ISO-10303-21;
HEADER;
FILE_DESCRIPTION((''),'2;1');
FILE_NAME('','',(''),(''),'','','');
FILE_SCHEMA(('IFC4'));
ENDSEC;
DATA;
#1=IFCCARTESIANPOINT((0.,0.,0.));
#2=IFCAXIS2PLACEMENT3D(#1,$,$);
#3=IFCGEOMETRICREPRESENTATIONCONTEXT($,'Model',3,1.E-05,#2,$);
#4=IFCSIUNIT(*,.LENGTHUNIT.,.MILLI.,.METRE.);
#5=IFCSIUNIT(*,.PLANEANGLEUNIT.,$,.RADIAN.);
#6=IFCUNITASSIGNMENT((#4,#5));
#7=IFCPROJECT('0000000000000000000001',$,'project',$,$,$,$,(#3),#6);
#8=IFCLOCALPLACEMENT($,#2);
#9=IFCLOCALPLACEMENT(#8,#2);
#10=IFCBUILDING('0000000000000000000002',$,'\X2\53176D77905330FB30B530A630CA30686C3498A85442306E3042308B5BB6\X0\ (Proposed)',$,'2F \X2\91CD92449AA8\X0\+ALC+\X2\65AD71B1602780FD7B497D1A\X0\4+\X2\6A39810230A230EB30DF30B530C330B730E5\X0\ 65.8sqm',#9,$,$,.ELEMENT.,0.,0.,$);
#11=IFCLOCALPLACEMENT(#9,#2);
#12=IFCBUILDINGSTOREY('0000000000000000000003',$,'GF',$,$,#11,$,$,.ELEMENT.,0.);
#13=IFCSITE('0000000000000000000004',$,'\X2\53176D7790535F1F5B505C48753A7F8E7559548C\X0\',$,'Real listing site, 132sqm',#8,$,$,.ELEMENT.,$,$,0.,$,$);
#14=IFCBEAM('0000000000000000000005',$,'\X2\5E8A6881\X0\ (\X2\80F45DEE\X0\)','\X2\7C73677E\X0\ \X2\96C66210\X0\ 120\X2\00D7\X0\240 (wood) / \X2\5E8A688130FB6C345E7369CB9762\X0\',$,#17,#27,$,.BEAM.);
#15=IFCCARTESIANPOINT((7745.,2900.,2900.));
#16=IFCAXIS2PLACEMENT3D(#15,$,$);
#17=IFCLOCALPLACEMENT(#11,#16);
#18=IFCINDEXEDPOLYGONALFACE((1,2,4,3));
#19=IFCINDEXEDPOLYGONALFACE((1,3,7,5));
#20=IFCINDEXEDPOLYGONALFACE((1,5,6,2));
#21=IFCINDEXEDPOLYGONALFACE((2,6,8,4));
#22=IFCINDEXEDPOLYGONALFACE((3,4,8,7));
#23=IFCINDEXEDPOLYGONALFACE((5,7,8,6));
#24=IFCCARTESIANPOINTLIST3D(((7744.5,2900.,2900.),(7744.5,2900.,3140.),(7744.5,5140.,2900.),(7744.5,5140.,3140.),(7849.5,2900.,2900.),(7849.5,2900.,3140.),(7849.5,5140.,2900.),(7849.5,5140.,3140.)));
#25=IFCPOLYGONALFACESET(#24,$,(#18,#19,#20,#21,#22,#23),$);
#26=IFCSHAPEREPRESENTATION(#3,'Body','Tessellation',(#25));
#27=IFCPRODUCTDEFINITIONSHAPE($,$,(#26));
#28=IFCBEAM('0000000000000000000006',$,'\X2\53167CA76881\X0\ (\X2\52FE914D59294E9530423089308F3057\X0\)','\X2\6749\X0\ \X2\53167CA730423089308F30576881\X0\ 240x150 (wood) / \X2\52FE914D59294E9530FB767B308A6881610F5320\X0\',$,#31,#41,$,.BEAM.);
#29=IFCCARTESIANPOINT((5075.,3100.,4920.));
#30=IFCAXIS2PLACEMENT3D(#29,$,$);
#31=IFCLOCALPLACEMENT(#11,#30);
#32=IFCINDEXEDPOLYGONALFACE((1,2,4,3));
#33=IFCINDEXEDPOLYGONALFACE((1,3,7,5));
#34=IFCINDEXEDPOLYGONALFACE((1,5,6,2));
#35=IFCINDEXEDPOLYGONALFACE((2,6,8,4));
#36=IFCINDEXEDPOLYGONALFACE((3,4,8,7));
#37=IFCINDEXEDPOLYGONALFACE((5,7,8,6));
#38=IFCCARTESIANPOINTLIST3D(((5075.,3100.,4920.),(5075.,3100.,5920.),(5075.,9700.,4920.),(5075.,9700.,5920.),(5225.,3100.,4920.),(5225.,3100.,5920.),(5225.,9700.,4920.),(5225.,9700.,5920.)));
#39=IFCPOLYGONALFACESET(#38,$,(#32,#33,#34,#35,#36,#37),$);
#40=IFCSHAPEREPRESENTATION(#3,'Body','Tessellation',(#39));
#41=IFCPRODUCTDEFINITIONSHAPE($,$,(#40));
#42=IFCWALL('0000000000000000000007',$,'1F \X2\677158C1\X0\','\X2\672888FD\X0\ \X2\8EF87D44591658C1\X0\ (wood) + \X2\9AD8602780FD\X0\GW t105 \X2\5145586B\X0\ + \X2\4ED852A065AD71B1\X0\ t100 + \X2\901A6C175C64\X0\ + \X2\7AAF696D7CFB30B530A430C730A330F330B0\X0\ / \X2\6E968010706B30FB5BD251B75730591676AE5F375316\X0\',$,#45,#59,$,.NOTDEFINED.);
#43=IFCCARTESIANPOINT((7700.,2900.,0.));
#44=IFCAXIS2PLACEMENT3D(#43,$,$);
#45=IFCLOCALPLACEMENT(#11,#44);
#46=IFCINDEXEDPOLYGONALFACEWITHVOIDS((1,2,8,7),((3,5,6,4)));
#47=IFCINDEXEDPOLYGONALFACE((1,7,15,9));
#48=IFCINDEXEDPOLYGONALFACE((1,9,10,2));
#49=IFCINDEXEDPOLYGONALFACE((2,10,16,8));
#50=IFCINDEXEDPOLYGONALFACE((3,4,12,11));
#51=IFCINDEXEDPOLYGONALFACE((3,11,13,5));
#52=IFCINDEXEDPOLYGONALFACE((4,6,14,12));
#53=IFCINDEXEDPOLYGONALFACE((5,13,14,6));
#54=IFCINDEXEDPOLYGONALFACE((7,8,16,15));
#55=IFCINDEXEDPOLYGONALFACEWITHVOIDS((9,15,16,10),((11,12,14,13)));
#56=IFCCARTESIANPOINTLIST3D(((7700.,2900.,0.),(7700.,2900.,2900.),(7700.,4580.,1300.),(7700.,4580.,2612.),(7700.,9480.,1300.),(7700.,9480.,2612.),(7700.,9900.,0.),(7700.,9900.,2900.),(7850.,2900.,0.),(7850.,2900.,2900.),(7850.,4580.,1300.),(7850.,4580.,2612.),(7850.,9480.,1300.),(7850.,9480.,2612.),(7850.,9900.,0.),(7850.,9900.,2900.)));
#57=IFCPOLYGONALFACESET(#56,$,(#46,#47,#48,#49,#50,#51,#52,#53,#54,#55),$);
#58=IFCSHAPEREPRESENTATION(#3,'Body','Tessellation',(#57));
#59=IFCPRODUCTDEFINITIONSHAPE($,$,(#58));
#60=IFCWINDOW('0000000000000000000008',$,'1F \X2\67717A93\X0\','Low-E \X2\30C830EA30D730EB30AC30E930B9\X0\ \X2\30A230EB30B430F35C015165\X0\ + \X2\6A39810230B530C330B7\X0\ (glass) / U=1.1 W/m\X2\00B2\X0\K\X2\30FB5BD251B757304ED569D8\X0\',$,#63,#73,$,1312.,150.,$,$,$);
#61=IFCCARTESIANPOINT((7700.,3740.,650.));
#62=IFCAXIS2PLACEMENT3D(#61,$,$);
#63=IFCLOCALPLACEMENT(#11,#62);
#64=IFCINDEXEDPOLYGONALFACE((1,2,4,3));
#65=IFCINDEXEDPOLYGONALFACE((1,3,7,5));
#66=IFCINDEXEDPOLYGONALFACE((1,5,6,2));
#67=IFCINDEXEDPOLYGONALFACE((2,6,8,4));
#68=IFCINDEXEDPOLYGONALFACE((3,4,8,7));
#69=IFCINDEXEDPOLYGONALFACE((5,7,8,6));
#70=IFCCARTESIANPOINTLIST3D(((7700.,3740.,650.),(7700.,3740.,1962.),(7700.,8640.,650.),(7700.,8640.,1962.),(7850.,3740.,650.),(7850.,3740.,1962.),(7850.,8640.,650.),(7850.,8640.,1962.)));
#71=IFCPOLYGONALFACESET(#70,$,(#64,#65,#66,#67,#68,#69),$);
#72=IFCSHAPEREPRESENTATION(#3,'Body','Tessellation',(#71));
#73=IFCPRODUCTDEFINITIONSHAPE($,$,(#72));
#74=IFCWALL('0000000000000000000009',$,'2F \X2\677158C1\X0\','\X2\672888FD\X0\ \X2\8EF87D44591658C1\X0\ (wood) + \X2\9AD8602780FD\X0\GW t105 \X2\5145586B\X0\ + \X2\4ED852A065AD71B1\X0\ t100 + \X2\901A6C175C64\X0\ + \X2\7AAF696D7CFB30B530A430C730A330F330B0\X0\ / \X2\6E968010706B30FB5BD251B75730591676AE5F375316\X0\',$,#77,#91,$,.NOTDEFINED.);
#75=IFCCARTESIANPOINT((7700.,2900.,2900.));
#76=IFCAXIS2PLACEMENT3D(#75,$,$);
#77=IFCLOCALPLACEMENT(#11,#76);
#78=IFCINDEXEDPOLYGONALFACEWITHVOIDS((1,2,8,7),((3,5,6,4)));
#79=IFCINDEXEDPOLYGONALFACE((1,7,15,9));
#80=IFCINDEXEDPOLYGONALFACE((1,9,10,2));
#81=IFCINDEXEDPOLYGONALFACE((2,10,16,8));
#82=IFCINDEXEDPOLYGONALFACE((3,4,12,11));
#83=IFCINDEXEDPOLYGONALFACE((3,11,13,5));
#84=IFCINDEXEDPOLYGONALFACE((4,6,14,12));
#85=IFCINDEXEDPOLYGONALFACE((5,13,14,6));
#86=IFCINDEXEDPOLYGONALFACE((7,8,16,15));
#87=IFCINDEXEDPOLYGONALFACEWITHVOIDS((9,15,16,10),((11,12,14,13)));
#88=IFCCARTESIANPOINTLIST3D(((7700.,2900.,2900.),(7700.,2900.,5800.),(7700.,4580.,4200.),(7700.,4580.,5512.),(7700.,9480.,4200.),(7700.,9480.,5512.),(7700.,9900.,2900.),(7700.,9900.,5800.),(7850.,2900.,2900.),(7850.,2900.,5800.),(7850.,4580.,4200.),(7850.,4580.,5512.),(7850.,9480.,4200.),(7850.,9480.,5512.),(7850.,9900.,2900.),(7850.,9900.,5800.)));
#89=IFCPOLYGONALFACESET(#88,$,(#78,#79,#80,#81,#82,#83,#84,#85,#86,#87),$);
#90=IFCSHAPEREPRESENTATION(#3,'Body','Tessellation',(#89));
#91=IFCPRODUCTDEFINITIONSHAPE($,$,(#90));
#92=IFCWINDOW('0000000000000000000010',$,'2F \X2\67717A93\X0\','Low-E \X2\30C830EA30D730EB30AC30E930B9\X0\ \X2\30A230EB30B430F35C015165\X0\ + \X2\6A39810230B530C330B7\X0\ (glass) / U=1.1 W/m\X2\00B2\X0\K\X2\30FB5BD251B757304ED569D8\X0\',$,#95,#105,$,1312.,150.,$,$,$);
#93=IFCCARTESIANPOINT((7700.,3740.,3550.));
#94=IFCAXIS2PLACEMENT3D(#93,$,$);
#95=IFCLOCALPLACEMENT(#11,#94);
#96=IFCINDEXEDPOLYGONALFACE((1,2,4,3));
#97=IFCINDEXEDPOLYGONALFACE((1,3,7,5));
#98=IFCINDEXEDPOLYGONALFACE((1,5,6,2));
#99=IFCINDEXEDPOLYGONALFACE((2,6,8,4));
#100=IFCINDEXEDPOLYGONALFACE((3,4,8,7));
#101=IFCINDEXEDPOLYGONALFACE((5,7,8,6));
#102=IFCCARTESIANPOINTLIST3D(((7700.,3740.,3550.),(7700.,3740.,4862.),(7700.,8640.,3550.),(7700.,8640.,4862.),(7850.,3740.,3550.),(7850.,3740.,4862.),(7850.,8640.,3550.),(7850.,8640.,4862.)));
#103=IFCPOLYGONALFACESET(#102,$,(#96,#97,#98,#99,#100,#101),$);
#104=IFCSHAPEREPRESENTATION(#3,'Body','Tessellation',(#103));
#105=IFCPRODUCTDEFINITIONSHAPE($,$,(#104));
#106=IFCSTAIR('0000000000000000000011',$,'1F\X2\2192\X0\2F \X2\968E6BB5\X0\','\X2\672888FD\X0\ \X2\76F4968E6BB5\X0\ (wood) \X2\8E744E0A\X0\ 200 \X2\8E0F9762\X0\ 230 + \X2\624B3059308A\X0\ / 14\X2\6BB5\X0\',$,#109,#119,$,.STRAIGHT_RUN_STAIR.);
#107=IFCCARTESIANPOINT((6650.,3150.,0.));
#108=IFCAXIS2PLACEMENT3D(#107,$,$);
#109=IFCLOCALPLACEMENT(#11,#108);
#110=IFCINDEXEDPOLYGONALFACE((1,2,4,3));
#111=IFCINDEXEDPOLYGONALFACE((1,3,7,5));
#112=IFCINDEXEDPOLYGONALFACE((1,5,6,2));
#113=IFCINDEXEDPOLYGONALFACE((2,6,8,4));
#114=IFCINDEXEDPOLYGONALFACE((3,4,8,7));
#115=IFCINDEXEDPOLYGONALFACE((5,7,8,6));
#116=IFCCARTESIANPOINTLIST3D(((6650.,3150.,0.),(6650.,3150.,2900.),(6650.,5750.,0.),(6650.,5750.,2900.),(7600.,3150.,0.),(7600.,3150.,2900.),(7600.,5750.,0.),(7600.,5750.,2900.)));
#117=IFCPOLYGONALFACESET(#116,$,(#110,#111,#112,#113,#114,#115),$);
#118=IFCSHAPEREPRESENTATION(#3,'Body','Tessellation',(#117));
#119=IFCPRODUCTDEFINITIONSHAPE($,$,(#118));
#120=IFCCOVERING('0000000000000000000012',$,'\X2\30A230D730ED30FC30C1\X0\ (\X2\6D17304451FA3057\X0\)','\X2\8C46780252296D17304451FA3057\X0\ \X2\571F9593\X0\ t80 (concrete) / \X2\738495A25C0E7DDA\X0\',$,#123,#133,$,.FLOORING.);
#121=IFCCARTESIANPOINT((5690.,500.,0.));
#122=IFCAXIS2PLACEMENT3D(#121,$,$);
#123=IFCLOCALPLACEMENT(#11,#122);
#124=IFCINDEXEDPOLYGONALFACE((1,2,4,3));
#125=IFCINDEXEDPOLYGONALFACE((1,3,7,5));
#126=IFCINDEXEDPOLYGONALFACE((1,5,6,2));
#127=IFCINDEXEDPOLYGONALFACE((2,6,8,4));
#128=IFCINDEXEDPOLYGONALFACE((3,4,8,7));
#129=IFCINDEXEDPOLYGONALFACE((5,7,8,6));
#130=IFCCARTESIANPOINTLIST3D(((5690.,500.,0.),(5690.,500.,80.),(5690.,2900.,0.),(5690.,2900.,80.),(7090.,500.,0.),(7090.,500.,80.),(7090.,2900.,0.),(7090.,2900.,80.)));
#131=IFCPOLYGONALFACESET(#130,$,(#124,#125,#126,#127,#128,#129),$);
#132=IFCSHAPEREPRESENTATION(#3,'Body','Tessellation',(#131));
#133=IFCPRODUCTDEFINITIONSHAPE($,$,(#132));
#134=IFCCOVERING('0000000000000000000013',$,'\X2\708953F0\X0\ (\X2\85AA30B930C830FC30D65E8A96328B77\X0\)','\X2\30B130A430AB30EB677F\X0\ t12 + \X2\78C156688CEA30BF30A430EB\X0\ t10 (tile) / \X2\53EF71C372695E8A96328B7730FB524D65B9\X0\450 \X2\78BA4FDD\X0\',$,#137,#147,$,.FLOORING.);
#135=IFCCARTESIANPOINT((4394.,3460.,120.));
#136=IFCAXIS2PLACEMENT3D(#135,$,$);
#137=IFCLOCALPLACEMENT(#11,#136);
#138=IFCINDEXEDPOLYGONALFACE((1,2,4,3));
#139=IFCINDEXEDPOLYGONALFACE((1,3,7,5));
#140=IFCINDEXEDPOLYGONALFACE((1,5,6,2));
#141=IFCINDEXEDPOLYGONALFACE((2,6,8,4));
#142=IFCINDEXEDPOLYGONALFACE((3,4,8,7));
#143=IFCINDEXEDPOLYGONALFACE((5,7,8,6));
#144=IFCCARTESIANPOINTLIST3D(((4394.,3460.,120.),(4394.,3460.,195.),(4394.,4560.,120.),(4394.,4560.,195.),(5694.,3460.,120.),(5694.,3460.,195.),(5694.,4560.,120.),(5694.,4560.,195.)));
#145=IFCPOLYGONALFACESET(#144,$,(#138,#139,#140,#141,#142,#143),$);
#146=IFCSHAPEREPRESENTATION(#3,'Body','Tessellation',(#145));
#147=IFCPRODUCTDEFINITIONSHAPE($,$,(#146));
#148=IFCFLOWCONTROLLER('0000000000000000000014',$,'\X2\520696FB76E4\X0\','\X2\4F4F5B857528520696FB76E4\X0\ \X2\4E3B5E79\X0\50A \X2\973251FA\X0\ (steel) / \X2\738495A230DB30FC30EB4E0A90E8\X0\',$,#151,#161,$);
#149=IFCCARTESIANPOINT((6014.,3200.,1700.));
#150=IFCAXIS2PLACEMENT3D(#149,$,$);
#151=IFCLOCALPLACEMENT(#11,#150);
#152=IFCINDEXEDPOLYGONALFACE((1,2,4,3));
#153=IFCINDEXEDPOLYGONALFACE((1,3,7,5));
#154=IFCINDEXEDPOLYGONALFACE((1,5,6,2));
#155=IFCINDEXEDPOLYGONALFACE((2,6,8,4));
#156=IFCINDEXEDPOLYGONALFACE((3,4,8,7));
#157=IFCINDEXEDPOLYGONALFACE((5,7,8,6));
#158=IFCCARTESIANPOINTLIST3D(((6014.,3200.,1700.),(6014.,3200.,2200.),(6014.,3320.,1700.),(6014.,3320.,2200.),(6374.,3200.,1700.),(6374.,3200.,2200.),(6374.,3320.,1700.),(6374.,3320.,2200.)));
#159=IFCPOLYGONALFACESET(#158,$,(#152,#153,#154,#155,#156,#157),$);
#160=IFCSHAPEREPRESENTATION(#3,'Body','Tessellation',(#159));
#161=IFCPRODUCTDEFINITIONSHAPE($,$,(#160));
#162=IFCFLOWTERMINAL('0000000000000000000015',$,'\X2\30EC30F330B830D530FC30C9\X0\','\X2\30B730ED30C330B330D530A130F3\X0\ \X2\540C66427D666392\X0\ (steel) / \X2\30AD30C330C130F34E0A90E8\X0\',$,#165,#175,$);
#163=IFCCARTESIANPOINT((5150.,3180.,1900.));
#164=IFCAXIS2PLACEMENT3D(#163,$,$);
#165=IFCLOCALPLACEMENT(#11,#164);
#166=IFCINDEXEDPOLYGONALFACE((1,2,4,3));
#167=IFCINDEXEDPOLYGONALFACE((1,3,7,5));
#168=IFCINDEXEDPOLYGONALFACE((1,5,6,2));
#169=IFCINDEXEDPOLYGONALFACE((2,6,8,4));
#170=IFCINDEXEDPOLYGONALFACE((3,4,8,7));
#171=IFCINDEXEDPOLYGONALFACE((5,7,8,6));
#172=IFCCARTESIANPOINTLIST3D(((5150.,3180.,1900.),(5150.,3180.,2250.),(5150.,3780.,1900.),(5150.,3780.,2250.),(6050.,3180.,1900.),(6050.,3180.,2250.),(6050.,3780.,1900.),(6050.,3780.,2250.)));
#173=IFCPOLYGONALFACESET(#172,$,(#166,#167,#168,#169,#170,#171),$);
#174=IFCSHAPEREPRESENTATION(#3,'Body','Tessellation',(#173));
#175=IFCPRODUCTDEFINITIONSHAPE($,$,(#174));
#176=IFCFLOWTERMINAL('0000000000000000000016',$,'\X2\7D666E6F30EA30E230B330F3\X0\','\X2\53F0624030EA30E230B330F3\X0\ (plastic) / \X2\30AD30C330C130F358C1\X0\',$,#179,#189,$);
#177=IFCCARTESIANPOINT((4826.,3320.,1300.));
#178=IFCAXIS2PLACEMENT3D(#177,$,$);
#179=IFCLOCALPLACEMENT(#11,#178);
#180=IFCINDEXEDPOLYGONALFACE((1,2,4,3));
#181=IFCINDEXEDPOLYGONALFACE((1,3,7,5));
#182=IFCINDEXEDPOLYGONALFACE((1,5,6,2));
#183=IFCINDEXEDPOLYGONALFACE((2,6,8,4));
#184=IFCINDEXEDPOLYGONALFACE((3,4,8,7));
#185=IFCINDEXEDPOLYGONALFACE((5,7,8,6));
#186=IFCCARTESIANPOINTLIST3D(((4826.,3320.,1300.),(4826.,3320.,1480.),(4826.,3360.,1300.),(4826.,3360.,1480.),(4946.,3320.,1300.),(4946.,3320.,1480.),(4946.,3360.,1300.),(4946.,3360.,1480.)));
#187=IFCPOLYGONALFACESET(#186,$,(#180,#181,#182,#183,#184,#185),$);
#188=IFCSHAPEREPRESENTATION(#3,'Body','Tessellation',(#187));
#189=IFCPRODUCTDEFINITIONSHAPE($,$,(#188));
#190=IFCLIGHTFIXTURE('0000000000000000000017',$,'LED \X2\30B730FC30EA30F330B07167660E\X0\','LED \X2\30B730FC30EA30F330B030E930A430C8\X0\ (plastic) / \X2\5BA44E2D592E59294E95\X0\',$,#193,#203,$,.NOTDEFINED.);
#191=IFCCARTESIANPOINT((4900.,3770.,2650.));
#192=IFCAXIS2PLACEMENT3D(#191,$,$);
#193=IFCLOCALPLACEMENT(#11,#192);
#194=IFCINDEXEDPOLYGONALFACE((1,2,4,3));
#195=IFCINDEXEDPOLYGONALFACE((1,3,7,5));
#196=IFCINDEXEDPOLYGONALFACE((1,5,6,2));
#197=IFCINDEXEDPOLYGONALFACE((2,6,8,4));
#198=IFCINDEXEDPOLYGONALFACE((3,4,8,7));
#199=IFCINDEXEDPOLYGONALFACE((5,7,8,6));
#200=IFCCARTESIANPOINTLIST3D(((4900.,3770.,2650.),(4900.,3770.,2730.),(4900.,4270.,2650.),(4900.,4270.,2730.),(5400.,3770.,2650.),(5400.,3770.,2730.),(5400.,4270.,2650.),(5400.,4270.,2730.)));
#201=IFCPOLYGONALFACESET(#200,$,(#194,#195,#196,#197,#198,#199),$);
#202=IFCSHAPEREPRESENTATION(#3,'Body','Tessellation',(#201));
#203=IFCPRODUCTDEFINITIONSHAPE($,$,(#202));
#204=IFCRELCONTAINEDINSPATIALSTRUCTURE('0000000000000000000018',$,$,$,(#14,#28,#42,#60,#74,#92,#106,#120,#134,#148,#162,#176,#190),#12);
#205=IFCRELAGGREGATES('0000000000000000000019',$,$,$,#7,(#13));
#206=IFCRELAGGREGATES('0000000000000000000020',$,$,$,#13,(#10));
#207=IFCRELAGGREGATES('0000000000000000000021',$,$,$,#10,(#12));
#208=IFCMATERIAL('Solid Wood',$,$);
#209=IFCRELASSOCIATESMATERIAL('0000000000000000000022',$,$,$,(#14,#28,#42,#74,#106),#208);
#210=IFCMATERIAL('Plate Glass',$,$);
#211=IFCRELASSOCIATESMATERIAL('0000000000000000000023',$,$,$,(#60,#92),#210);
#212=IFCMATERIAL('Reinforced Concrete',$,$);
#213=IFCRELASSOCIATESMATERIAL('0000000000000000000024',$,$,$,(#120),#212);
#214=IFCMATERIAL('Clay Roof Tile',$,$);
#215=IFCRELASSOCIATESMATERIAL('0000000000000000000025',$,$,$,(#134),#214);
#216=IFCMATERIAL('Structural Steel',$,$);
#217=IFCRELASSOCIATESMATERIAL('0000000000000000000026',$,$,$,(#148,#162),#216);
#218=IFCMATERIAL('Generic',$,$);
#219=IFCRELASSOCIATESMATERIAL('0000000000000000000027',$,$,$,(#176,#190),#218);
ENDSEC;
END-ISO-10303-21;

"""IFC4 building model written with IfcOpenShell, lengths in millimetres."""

from ifc_helpers import new_model, si_unit, frame, frame_2d, origin, place, context, project, spatial, rectangle, extrude, material, element, fill, save


model = new_model("IFC4")

# Units and contexts
model_context = context("Model", 3, precision=1e-05, world=origin())
ifc_project = project(units=[si_unit("LENGTHUNIT", "METRE", prefix="MILLI"), si_unit("PLANEANGLEUNIT", "RADIAN")], contexts=[model_context])

# Site, building, storey
site_placement = place(None, origin())
site = spatial("IfcSite", under=ifc_project, at=site_placement, Name="北海道弟子屈町美留和", ObjectType="Real listing site, 132sqm", CompositionType="ELEMENT", RefElevation=0.0)
building_placement = place(site_placement, origin())
building = spatial("IfcBuilding", under=site, at=building_placement, Name="北海道・サウナと水風呂のある家 (Proposed)", ObjectType="2F 重鉄骨+ALC+断熱性能等級4+樹脂アルミサッシュ 65.8sqm", CompositionType="ELEMENT", ElevationOfRefHeight=0.0, ElevationOfTerrain=0.0)
storey_placement = place(building_placement, origin())
storey = spatial("IfcBuildingStorey", under=building, at=storey_placement, Name="GF", CompositionType="ELEMENT", Elevation=0.0)

# Shared definitions
ifc_material_1 = material(Name="Solid Wood")

# Beams
beam_1_placement = place(storey_placement, frame((7745.0, 2900.0, 2900.0)))
element("IfcBeam", 1, at=beam_1_placement, inside=storey, material=ifc_material_1, Name="床梁 (胴差)", Description="米松 集成 120×240 (wood) / 床梁・水平構面", PredefinedType="BEAM", context=model_context, shape_type="SweptSolid", body=[
    extrude(rectangle(XDim=105.0, YDim=2240.0, at=frame_2d((52.0, 1120.0))), frame((7745.0, 2900.0, 2900.0)), (0.0, 0.0, 1.0), 240.0),
])
beam_2_placement = place(storey_placement, frame((5075.0, 3100.0, 4920.0)))
element("IfcBeam", 2, at=beam_2_placement, inside=storey, material=ifc_material_1, Name="化粧梁 (勾配天井あらわし)", Description="杉 化粧あらわし梁 240x150 (wood) / 勾配天井・登り梁意匠", PredefinedType="BEAM", context=model_context, shape_type="SweptSolid", body=[
    extrude(rectangle(XDim=150.0, YDim=6600.0, at=frame_2d((75.0, 3300.0))), frame((5075.0, 3100.0, 4920.0)), (0.0, 0.0, 1.0), 1000.0),
])

# Wall, opening, window
wall_1_placement = place(storey_placement, frame((7700.0, 2900.0, 0.0)))
wall_1 = element("IfcWall", 3, at=wall_1_placement, inside=storey, material=ifc_material_1, Name="1F 東壁", Description="木製 軸組外壁 (wood) + 高性能GW t105 充填 + 付加断熱 t100 + 通気層 + 窯業系サイディング / 準耐火・寒冷地外皮強化", PredefinedType="NOTDEFINED", context=model_context, shape_type="SweptSolid", body=[
    extrude(rectangle(XDim=150.0, YDim=7000.0, at=frame_2d((75.0, 3500.0))), frame((7700.0, 2900.0, 0.0)), (0.0, 0.0, 1.0), 2900.0),
])
opening_1_placement = place(storey_placement, frame((7700.0, 3740.0, 650.0)))
opening_1 = element("IfcOpeningElement", 4, at=opening_1_placement, cuts=wall_1, PredefinedType="NOTDEFINED", context=model_context, shape_type="SweptSolid", body=[
    extrude(rectangle(XDim=150.0, YDim=4900.0, at=frame_2d((75.0, 2450.0))), frame((7700.0, 3740.0, 650.0)), (0.0, 0.0, 1.0), 1312.0),
])
ifc_material_2 = material(Name="Plate Glass")
window_1_placement = place(storey_placement, frame((7700.0, 3740.0, 650.0)))
window_1 = element("IfcWindow", 5, at=window_1_placement, inside=storey, material=ifc_material_2, Name="1F 東窓", Description="Low-E トリプルガラス アルゴン封入 + 樹脂サッシ (glass) / U=1.1 W/m²K・寒冷地仕様", OverallHeight=1312.0, OverallWidth=150.0, context=model_context, shape_type="SweptSolid", body=[
    extrude(rectangle(XDim=150.0, YDim=4900.0, at=frame_2d((75.0, 2450.0))), frame((7700.0, 3740.0, 650.0)), (0.0, 0.0, 1.0), 1312.0),
])
fill(opening_1, window_1)

# Wall, opening, window
wall_2_placement = place(storey_placement, frame((7700.0, 2900.0, 2900.0)))
wall_2 = element("IfcWall", 6, at=wall_2_placement, inside=storey, material=ifc_material_1, Name="2F 東壁", Description="木製 軸組外壁 (wood) + 高性能GW t105 充填 + 付加断熱 t100 + 通気層 + 窯業系サイディング / 準耐火・寒冷地外皮強化", PredefinedType="NOTDEFINED", context=model_context, shape_type="SweptSolid", body=[
    extrude(rectangle(XDim=150.0, YDim=7000.0, at=frame_2d((75.0, 3500.0))), frame((7700.0, 2900.0, 2900.0)), (0.0, 0.0, 1.0), 2900.0),
])
opening_2_placement = place(storey_placement, frame((7700.0, 3740.0, 3550.0)))
opening_2 = element("IfcOpeningElement", 7, at=opening_2_placement, cuts=wall_2, PredefinedType="NOTDEFINED", context=model_context, shape_type="SweptSolid", body=[
    extrude(rectangle(XDim=150.0, YDim=4900.0, at=frame_2d((75.0, 2450.0))), frame((7700.0, 3740.0, 3550.0)), (0.0, 0.0, 1.0), 1312.0),
])
window_2_placement = place(storey_placement, frame((7700.0, 3740.0, 3550.0)))
window_2 = element("IfcWindow", 8, at=window_2_placement, inside=storey, material=ifc_material_2, Name="2F 東窓", Description="Low-E トリプルガラス アルゴン封入 + 樹脂サッシ (glass) / U=1.1 W/m²K・寒冷地仕様", OverallHeight=1312.0, OverallWidth=150.0, context=model_context, shape_type="SweptSolid", body=[
    extrude(rectangle(XDim=150.0, YDim=4900.0, at=frame_2d((75.0, 2450.0))), frame((7700.0, 3740.0, 3550.0)), (0.0, 0.0, 1.0), 1312.0),
])
fill(opening_2, window_2)

# Stair
stair_placement = place(storey_placement, frame((6650.0, 3150.0, 0.0)))
element("IfcStair", 9, at=stair_placement, inside=storey, material=ifc_material_1, Name="1F→2F 階段", Description="木製 直階段 (wood) 蹴上 200 踏面 230 + 手すり / 14段", PredefinedType="STRAIGHT_RUN_STAIR", context=model_context, shape_type="SweptSolid", body=[
    extrude(rectangle(XDim=950.0, YDim=2600.0, at=frame_2d((475.0, 1300.0))), frame((6650.0, 3150.0, 0.0)), (0.0, 0.0, 1.0), 2900.0),
])

# Coverings
ifc_material_3 = material(Name="Reinforced Concrete")
covering_1_placement = place(storey_placement, frame((5690.0, 500.0, 0.0)))
element("IfcCovering", 10, at=covering_1_placement, inside=storey, material=ifc_material_3, Name="アプローチ (洗い出し)", Description="豆砂利洗い出し 土間 t80 (concrete) / 玄関導線", PredefinedType="FLOORING", context=model_context, shape_type="SweptSolid", body=[
    extrude(rectangle(XDim=1400.0, YDim=2400.0, at=frame_2d((700.0, 1200.0))), frame((5690.0, 500.0, 0.0)), (0.0, 0.0, 1.0), 80.0),
])
ifc_material_4 = material(Name="Clay Roof Tile")
covering_2_placement = place(storey_placement, frame((4394.0, 3460.0, 120.0)))
element("IfcCovering", 11, at=covering_2_placement, inside=storey, material=ifc_material_4, Name="炉台 (薪ストーブ床防護)", Description="ケイカル板 t12 + 磁器質タイル t10 (tile) / 可燃物床防護・前方450 確保", PredefinedType="FLOORING", context=model_context, shape_type="SweptSolid", body=[
    extrude(rectangle(XDim=1300.0, YDim=1100.0, at=frame_2d((650.0, 550.0))), frame((4394.0, 3460.0, 120.0)), (0.0, 0.0, 1.0), 75.0),
])

# Flow controller
ifc_material_5 = material(Name="Structural Steel")
flow_controller_placement = place(storey_placement, frame((6014.0, 3200.0, 1700.0)))
element("IfcFlowController", 12, at=flow_controller_placement, inside=storey, material=ifc_material_5, Name="分電盤", Description="住宅用分電盤 主幹50A 露出 (steel) / 玄関ホール上部", context=model_context, shape_type="SweptSolid", body=[
    extrude(rectangle(XDim=360.0, YDim=120.0, at=frame_2d((180.0, 60.0))), frame((6014.0, 3200.0, 1700.0)), (0.0, 0.0, 1.0), 500.0),
])

# Flow terminals
flow_terminal_1_placement = place(storey_placement, frame((5150.0, 3180.0, 1900.0)))
element("IfcFlowTerminal", 13, at=flow_terminal_1_placement, inside=storey, material=ifc_material_5, Name="レンジフード", Description="シロッコファン 同時給排 (steel) / キッチン上部", context=model_context, shape_type="SweptSolid", body=[
    extrude(rectangle(XDim=900.0, YDim=600.0, at=frame_2d((450.0, 300.0))), frame((5150.0, 3180.0, 1900.0)), (0.0, 0.0, 1.0), 350.0),
])
ifc_material_6 = material(Name="Generic")
flow_terminal_2_placement = place(storey_placement, frame((4826.0, 3320.0, 1300.0)))
element("IfcFlowTerminal", 14, at=flow_terminal_2_placement, inside=storey, material=ifc_material_6, Name="給湯リモコン", Description="台所リモコン (plastic) / キッチン壁", context=model_context, shape_type="SweptSolid", body=[
    extrude(rectangle(XDim=120.0, YDim=40.0, at=frame_2d((60.0, 20.0))), frame((4826.0, 3320.0, 1300.0)), (0.0, 0.0, 1.0), 180.0),
])

# Light fixture
light_fixture_placement = place(storey_placement, frame((4900.0, 3770.0, 2650.0)))
element("IfcLightFixture", 15, at=light_fixture_placement, inside=storey, material=ifc_material_6, Name="LED シーリング照明", Description="LED シーリングライト (plastic) / 室中央天井", PredefinedType="NOTDEFINED", context=model_context, shape_type="SweptSolid", body=[
    extrude(rectangle(XDim=500.0, YDim=500.0, at=frame_2d((250.0, 250.0))), frame((4900.0, 3770.0, 2650.0)), (0.0, 0.0, 1.0), 80.0),
])

save(model, "model.ifc")
